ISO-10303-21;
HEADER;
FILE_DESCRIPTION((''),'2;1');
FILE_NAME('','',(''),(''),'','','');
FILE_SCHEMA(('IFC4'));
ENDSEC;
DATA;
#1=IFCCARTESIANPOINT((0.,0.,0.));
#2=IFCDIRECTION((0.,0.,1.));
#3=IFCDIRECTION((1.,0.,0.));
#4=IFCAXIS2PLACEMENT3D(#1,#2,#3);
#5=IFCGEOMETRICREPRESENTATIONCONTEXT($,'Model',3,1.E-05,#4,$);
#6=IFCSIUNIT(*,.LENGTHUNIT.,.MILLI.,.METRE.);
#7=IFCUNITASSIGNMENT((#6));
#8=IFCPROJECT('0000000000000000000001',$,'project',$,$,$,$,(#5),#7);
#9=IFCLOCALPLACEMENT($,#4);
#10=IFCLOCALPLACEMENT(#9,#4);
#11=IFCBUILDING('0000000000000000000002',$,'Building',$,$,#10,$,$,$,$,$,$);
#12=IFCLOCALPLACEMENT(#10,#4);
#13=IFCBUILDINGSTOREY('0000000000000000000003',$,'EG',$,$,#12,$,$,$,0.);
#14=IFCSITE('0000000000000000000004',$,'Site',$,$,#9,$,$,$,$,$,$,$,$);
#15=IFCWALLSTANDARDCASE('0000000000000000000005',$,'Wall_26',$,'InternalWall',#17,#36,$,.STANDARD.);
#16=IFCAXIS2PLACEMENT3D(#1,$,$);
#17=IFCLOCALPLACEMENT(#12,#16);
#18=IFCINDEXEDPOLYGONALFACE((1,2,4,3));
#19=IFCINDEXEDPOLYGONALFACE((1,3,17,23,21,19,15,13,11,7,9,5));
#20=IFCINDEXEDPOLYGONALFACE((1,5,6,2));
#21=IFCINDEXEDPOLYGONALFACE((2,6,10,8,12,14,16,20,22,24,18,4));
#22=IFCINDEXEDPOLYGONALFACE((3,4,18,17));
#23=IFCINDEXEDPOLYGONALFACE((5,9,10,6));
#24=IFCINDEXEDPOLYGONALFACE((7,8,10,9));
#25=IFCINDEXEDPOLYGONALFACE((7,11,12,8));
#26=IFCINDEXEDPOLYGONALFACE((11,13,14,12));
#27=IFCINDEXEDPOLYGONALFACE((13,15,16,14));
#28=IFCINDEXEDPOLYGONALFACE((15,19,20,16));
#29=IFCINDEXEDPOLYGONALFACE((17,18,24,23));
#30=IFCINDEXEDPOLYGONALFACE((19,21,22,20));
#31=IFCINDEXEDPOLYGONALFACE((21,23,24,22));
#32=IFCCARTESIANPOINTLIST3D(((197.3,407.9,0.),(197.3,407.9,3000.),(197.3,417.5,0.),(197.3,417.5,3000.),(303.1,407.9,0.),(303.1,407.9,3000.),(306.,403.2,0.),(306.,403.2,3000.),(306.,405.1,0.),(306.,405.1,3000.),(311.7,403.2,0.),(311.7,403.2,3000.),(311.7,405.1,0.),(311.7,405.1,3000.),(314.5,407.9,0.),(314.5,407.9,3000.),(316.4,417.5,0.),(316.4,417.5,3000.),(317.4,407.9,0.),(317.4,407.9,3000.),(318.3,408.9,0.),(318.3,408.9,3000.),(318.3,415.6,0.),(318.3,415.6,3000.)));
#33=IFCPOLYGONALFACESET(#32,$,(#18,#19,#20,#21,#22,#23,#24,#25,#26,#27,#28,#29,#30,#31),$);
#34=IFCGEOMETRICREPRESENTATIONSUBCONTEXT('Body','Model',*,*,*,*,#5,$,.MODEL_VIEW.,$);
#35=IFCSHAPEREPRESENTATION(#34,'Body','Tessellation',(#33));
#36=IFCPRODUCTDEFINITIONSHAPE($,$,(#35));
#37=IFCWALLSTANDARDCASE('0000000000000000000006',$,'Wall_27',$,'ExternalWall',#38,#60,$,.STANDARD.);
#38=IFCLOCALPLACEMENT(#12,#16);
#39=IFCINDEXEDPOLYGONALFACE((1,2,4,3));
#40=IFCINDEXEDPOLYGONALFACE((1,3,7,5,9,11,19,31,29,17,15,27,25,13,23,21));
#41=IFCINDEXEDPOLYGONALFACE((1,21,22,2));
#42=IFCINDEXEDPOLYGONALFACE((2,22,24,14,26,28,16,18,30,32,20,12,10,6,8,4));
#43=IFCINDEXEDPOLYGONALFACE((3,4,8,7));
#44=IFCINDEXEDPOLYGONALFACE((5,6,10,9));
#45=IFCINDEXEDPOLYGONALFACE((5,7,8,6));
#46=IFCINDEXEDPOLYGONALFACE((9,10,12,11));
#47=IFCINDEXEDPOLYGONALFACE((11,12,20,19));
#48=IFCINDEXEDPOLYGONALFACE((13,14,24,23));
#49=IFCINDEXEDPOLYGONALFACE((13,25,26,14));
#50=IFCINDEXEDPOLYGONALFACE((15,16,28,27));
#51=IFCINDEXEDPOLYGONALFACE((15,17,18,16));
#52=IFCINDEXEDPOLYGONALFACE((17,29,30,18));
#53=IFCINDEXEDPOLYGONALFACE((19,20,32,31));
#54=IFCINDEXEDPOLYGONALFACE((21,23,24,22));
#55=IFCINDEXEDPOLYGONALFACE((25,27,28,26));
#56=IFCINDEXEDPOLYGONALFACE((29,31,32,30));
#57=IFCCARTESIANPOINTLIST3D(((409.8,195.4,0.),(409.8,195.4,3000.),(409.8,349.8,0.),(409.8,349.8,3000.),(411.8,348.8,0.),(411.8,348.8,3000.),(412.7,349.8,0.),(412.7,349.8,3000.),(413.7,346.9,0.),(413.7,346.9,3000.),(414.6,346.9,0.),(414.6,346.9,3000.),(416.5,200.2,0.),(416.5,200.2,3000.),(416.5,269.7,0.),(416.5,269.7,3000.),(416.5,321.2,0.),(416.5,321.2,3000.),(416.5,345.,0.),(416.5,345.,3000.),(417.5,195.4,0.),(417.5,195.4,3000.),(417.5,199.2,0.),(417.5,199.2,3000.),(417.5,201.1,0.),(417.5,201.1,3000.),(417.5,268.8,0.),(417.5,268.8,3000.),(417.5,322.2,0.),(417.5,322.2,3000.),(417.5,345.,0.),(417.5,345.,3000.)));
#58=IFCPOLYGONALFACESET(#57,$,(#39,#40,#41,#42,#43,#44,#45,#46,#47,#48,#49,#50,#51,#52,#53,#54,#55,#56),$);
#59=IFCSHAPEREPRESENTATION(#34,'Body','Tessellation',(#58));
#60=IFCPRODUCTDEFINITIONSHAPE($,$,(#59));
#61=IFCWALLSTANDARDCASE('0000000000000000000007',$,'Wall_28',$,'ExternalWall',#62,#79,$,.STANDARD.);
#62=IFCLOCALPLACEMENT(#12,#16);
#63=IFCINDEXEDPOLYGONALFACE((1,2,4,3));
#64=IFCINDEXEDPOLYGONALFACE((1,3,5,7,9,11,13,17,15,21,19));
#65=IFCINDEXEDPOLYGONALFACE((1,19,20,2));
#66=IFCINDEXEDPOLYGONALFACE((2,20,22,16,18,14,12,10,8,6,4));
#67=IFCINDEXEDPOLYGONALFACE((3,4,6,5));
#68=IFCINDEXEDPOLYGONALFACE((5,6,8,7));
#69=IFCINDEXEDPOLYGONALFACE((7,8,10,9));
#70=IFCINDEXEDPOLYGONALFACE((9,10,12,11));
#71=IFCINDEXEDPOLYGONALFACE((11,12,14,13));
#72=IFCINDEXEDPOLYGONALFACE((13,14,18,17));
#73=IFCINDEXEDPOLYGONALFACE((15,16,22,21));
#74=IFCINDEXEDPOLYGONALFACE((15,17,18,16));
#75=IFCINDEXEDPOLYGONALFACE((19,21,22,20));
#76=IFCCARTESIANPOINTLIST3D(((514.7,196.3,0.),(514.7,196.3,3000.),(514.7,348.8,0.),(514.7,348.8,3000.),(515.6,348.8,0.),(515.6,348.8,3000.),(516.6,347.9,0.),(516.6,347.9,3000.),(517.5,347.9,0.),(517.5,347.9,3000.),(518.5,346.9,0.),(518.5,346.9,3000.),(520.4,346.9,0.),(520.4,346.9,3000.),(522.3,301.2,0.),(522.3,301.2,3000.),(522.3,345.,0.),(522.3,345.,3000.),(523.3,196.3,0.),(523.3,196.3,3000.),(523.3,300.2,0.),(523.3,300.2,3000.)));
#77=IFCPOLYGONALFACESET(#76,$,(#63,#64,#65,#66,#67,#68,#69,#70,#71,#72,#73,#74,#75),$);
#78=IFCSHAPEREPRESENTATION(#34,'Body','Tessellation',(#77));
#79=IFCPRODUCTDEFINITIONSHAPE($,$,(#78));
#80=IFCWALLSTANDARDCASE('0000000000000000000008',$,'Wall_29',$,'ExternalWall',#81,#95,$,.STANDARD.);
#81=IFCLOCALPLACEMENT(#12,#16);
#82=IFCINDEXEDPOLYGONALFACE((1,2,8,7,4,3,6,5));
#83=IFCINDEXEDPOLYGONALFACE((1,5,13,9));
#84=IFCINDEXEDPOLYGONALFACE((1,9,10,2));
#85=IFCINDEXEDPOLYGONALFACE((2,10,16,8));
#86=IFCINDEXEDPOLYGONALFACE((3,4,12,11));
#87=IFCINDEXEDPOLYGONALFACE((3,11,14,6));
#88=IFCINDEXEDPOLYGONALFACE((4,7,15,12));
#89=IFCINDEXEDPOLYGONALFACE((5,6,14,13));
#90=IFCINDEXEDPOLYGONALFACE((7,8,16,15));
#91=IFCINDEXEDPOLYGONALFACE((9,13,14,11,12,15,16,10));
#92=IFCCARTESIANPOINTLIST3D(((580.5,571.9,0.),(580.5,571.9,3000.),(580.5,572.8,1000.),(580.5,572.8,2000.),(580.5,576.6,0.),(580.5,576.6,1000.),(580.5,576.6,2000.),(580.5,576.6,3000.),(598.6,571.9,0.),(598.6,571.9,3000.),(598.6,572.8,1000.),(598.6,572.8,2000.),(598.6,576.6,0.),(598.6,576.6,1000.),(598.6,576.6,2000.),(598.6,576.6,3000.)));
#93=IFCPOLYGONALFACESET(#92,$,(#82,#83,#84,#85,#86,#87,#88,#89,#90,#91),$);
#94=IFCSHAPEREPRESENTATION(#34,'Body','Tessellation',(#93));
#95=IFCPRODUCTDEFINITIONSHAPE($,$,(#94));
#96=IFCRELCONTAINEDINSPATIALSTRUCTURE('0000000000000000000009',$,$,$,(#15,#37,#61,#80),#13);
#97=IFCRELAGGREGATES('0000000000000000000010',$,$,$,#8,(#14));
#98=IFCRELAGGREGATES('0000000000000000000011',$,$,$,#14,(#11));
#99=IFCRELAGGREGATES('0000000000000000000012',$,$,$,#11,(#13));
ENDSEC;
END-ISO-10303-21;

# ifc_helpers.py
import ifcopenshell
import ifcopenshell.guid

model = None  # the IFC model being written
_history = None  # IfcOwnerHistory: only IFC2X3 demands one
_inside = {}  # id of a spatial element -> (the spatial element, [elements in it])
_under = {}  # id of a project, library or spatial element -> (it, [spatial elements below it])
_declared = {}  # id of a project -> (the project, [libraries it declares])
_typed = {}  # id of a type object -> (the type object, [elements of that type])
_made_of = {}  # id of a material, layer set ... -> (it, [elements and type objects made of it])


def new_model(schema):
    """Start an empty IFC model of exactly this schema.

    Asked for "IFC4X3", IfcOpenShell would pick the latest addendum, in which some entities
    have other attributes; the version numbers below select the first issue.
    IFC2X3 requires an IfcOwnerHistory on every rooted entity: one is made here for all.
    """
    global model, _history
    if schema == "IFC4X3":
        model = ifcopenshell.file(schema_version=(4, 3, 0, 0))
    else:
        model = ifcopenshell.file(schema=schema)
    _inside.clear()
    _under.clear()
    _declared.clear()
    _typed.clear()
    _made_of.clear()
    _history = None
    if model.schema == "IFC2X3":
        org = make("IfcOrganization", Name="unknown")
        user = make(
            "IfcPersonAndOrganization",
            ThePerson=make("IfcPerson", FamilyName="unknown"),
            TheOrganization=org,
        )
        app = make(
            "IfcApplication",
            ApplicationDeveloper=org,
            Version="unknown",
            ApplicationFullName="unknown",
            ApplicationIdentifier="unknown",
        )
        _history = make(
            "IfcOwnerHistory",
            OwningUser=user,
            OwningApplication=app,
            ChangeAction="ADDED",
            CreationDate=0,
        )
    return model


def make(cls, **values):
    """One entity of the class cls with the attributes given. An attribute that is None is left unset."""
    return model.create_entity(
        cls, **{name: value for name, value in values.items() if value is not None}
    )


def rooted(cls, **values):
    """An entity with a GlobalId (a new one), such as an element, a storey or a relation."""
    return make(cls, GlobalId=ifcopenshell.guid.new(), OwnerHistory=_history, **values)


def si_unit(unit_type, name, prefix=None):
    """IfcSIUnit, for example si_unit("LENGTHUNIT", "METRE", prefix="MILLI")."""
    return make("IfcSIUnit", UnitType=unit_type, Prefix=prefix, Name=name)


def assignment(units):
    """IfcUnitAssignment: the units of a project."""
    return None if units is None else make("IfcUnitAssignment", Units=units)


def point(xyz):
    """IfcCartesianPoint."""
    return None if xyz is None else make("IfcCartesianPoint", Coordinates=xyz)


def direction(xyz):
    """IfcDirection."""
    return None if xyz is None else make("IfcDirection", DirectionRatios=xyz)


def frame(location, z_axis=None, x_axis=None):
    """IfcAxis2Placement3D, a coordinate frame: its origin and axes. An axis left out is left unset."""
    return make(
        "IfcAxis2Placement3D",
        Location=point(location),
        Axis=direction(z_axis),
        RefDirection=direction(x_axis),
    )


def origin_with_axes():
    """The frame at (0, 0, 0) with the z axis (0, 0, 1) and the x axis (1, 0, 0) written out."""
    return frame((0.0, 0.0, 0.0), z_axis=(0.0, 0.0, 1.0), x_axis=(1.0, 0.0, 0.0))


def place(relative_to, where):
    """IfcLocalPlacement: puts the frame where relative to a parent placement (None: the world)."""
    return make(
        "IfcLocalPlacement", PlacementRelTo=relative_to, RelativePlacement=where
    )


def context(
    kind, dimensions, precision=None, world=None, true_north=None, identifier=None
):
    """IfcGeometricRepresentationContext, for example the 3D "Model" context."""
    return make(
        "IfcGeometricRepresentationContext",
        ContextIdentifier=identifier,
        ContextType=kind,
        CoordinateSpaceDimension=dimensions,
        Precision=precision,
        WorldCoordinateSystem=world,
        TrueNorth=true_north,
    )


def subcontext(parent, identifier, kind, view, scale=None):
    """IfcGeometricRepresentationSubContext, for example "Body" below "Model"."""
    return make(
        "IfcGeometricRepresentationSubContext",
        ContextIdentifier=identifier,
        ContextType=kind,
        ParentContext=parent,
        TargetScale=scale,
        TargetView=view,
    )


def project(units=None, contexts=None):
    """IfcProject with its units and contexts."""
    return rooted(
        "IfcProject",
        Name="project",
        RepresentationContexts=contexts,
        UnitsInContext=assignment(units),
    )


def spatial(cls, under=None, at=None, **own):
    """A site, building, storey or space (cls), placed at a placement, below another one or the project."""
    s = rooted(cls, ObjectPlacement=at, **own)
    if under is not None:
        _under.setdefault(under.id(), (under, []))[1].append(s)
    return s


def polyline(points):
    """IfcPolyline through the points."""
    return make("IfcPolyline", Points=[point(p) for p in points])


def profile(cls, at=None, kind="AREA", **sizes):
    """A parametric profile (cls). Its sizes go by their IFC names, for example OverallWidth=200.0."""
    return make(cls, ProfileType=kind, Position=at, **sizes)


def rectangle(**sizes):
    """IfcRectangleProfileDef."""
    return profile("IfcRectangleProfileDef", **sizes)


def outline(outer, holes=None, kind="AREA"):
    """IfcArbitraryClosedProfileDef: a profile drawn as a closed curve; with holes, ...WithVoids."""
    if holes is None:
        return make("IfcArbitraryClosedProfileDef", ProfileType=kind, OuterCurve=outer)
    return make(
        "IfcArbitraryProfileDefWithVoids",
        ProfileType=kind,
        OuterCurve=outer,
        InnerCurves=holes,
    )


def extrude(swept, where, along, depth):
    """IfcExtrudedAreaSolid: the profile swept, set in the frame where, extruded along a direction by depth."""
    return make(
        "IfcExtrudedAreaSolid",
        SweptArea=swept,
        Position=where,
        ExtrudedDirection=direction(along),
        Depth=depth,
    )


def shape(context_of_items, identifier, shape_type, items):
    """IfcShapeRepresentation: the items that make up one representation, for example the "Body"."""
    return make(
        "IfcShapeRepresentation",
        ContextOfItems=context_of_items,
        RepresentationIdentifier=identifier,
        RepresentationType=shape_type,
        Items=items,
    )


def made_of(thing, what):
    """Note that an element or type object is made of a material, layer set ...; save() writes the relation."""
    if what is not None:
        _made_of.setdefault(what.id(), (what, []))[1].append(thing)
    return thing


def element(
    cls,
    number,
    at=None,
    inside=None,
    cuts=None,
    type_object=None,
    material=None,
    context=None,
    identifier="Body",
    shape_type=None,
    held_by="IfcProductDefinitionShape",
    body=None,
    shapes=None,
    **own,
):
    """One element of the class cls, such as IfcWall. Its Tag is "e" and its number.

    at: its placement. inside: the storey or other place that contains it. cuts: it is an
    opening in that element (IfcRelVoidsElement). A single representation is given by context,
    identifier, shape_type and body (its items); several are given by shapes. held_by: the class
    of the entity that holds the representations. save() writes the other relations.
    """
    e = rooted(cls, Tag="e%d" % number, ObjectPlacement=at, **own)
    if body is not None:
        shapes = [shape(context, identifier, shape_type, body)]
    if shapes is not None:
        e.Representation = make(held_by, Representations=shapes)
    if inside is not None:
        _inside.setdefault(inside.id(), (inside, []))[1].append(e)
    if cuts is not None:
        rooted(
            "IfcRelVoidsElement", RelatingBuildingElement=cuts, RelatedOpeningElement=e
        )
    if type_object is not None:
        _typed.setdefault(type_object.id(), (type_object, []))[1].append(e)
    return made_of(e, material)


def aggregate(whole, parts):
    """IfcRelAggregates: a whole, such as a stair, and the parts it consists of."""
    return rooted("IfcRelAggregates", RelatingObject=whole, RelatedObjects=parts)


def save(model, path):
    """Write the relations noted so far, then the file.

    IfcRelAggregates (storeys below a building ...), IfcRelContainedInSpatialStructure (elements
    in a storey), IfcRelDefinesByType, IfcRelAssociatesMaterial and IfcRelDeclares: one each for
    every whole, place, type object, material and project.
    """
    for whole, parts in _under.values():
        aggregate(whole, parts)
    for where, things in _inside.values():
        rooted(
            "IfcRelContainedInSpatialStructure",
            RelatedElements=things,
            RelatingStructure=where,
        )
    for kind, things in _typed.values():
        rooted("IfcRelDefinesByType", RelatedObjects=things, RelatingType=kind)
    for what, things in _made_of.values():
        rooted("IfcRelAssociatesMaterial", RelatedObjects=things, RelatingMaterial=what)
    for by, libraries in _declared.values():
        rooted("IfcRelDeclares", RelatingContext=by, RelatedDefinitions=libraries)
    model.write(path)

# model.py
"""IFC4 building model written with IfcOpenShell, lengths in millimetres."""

from ifc_helpers import new_model, si_unit, frame, origin_with_axes, place, context, subcontext, project, spatial, polyline, rectangle, outline, extrude, element, save


model = new_model("IFC4")

# Units and contexts
model_context = context("Model", 3, precision=1e-05, world=origin_with_axes())
body_context = subcontext(model_context, "Body", "Model", "MODEL_VIEW")
ifc_project = project(units=[si_unit("LENGTHUNIT", "METRE", prefix="MILLI")], contexts=[model_context])

# Site, building, storey
site_placement = place(None, origin_with_axes())
site = spatial("IfcSite", under=ifc_project, at=site_placement, Name="Site")
building_placement = place(site_placement, origin_with_axes())
building = spatial("IfcBuilding", under=site, at=building_placement, Name="Building")
storey_placement = place(building_placement, origin_with_axes())
storey = spatial("IfcBuildingStorey", under=building, at=storey_placement, Name="EG", Elevation=0.0)

# Walls
wall_1_placement = place(storey_placement, origin_with_axes())
element("IfcWallStandardCase", 1, at=wall_1_placement, inside=storey, Name="Wall_26", ObjectType="InternalWall", PredefinedType="STANDARD", context=body_context, shape_type="SweptSolid", body=[
    extrude(outline(polyline([(306.0, 403.2, 0.0), (306.0, 405.1, 0.0), (303.1, 407.9, 0.0), (197.3, 407.9, 0.0), (197.3, 417.5, 0.0), (316.4, 417.5, 0.0), (318.3, 415.6, 0.0), (318.3, 408.9, 0.0), (317.4, 407.9, 0.0), (314.5, 407.9, 0.0), (311.7, 405.1, 0.0), (311.7, 403.2, 0.0), (306.0, 403.2, 0.0)])), origin_with_axes(), (0.0, 0.0, 1.0), 3000.0),
])
wall_2_placement = place(storey_placement, origin_with_axes())
element("IfcWallStandardCase", 2, at=wall_2_placement, inside=storey, Name="Wall_27", ObjectType="ExternalWall", PredefinedType="STANDARD", context=body_context, shape_type="SweptSolid", body=[
    extrude(outline(polyline([(409.8, 195.4, 0.0), (409.8, 349.8, 0.0), (412.7, 349.8, 0.0), (411.8, 348.8, 0.0), (413.7, 346.9, 0.0), (414.6, 346.9, 0.0), (416.5, 345.0, 0.0), (417.5, 345.0, 0.0), (417.5, 322.2, 0.0), (416.5, 321.2, 0.0), (416.5, 269.7, 0.0), (417.5, 268.8, 0.0), (417.5, 201.1, 0.0), (416.5, 200.2, 0.0), (417.5, 199.2, 0.0), (417.5, 195.4, 0.0), (409.8, 195.4, 0.0)])), origin_with_axes(), (0.0, 0.0, 1.0), 3000.0),
])
wall_3_placement = place(storey_placement, origin_with_axes())
element("IfcWallStandardCase", 3, at=wall_3_placement, inside=storey, Name="Wall_28", ObjectType="ExternalWall", PredefinedType="STANDARD", context=body_context, shape_type="SweptSolid", body=[
    extrude(outline(polyline([(514.7, 196.3, 0.0), (514.7, 348.8, 0.0), (515.6, 348.8, 0.0), (516.6, 347.9, 0.0), (517.5, 347.9, 0.0), (518.5, 346.9, 0.0), (520.4, 346.9, 0.0), (522.3, 345.0, 0.0), (522.3, 301.2, 0.0), (523.3, 300.2, 0.0), (523.3, 196.3, 0.0), (514.7, 196.3, 0.0)])), origin_with_axes(), (0.0, 0.0, 1.0), 3000.0),
])

# Wall, opening
wall_4_placement = place(storey_placement, origin_with_axes())
wall_4 = element("IfcWallStandardCase", 4, at=wall_4_placement, inside=storey, Name="Wall_29", ObjectType="ExternalWall", PredefinedType="STANDARD", context=body_context, shape_type="SweptSolid", body=[
    extrude(outline(polyline([(580.5, 571.9, 0.0), (580.5, 576.6, 0.0), (598.6, 576.6, 0.0), (598.6, 571.9, 0.0), (580.5, 571.9, 0.0)])), origin_with_axes(), (0.0, 0.0, 1.0), 3000.0),
])
opening_1_placement = place(wall_4_placement, origin_with_axes())
element("IfcOpeningElement", 5, at=opening_1_placement, inside=storey, cuts=wall_4, context=body_context, shape_type="SweptSolid", body=[
    extrude(rectangle(XDim=1200.0, YDim=4.8), frame((560.4, 575.2, 1000.0), z_axis=(0.0, 0.0, 1.0), x_axis=(1.0, 0.0, 0.0)), (0.0, 0.0, 1.0), 1000.0),
])

save(model, "model.ifc")
